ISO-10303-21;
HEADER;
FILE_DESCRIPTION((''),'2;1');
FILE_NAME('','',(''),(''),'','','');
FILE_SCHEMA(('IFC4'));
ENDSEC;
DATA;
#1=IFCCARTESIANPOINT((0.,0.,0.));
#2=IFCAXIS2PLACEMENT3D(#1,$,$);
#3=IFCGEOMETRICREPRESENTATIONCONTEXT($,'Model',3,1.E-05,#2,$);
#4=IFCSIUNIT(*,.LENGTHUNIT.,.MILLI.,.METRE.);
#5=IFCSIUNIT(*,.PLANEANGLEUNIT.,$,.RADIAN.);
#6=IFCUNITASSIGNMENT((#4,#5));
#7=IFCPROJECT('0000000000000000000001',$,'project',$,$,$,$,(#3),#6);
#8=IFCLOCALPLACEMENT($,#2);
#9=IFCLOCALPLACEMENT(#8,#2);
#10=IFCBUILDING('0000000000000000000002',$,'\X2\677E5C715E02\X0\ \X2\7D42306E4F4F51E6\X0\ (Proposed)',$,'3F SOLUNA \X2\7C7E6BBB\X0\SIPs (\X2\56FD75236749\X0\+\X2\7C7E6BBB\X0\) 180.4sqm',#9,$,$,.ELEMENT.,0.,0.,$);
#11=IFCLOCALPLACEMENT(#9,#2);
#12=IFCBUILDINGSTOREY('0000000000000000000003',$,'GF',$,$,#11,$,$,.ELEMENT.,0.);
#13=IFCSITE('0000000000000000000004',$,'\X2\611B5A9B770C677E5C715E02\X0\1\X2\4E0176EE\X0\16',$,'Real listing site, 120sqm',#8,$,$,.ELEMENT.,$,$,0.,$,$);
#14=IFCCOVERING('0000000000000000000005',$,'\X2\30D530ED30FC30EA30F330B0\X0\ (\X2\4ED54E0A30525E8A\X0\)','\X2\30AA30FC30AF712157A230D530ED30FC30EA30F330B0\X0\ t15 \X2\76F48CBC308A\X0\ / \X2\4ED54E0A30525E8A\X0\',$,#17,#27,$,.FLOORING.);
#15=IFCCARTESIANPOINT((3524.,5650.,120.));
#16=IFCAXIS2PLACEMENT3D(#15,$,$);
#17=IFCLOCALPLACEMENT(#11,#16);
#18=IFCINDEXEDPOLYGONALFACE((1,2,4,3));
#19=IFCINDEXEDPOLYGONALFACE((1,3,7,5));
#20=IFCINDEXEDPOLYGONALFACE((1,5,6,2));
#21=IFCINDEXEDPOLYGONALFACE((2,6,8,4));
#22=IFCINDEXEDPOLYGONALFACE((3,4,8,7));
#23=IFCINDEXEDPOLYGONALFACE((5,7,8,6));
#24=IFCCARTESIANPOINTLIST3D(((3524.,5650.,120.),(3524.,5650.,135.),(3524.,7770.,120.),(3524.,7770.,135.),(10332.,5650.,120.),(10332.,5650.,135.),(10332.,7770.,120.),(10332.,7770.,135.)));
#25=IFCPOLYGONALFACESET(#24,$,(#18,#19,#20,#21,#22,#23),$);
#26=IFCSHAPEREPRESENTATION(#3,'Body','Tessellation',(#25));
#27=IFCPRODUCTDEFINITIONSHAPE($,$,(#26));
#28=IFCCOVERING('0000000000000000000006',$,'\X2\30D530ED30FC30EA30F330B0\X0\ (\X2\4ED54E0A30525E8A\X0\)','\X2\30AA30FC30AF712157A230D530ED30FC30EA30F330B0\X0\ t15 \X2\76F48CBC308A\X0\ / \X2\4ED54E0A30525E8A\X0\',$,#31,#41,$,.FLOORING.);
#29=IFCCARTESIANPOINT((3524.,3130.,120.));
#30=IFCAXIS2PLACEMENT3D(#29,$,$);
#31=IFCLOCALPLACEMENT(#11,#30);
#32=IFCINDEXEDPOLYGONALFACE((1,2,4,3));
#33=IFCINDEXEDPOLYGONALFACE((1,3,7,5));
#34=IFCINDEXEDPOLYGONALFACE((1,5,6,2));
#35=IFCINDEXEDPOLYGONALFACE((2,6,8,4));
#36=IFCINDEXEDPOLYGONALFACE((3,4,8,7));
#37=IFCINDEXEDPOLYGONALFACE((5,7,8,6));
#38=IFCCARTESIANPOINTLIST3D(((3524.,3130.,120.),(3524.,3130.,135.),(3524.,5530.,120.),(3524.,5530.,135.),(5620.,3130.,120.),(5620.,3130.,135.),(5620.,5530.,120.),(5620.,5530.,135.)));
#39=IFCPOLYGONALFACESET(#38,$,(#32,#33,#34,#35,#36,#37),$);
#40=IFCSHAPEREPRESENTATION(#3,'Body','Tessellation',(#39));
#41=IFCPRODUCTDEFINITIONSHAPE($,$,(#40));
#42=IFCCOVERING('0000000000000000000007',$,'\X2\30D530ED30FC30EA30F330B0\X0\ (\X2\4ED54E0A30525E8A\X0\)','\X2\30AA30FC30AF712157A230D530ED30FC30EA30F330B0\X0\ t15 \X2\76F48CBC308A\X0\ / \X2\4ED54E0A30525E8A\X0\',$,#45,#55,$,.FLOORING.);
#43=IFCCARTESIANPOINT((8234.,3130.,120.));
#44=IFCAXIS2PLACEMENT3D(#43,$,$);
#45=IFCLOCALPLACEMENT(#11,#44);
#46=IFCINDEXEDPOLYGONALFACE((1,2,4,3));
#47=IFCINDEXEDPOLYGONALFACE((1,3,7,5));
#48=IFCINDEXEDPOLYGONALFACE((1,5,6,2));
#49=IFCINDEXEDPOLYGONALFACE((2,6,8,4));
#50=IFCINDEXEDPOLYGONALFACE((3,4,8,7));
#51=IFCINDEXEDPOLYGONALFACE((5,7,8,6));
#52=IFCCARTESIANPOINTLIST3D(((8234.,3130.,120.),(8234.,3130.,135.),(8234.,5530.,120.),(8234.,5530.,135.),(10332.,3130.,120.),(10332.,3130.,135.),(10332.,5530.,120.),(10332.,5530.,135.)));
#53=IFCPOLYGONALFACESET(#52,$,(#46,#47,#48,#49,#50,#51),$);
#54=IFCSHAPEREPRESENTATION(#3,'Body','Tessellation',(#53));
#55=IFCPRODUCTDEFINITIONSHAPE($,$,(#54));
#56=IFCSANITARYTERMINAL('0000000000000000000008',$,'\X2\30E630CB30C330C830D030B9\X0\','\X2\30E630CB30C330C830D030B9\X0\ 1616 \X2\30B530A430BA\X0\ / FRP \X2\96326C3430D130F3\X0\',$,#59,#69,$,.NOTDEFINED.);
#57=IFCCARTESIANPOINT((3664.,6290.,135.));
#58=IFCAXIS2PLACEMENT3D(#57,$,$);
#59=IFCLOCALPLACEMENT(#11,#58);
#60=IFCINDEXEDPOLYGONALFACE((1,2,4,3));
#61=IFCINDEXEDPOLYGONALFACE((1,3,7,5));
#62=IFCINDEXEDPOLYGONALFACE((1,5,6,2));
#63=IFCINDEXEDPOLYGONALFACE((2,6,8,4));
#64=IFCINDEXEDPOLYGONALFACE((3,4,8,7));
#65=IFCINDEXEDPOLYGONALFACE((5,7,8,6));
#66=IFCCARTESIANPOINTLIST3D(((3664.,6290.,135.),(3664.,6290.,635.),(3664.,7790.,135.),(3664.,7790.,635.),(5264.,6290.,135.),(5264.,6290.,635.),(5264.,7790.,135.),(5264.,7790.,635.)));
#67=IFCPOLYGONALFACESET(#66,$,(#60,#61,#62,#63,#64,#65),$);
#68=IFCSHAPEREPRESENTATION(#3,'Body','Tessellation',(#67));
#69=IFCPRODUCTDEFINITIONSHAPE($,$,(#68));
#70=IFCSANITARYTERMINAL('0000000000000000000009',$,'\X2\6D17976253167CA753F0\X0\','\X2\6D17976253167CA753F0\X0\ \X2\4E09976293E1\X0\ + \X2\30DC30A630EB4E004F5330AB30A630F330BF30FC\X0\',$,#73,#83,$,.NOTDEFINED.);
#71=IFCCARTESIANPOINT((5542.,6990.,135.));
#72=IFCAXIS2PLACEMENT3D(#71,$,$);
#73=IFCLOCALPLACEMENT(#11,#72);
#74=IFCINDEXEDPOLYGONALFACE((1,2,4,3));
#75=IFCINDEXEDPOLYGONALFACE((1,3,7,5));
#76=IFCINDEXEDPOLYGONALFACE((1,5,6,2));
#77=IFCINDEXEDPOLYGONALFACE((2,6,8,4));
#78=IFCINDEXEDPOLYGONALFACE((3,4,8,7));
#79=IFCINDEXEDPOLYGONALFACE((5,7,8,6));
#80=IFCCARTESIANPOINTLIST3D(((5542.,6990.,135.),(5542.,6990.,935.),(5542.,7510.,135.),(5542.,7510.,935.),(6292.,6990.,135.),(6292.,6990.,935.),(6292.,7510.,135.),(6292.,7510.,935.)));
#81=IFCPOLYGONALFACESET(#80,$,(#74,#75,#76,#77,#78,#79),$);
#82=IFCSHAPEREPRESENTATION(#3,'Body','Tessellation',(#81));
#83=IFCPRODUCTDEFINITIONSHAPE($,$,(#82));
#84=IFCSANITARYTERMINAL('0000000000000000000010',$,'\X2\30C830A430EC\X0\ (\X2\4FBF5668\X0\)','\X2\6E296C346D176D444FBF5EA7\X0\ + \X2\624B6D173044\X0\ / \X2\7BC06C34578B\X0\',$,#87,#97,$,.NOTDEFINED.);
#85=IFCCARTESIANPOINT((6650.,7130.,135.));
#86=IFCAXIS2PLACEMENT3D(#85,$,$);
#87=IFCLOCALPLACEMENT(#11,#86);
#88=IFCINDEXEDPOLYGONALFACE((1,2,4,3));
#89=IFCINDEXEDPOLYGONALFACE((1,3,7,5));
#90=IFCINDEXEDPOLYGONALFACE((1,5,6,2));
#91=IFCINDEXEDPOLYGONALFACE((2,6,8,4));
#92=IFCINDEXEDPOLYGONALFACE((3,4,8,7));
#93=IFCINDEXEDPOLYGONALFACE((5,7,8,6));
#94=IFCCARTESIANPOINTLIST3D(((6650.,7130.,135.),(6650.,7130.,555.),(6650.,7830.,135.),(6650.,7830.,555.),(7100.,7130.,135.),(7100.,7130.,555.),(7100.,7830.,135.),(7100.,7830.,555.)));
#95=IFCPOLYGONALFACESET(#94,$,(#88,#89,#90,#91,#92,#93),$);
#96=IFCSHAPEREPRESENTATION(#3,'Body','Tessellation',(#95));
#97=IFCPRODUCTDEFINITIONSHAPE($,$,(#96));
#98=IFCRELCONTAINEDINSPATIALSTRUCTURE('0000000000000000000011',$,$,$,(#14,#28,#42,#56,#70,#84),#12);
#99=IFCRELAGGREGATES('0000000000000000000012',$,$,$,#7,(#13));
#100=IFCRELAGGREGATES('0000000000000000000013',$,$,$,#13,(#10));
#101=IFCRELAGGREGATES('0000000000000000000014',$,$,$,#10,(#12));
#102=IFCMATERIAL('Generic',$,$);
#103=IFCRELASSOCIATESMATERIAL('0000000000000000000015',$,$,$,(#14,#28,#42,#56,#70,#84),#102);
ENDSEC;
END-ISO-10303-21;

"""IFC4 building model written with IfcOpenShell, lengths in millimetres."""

from ifc_helpers import new_model, si_unit, frame, frame_2d, origin, place, context, project, spatial, rectangle, extrude, material, element, save


model = new_model("IFC4")

# Units and contexts
model_context = context("Model", 3, precision=1e-05, world=origin())
ifc_project = project(units=[si_unit("LENGTHUNIT", "METRE", prefix="MILLI"), si_unit("PLANEANGLEUNIT", "RADIAN")], contexts=[model_context])

# Site, building, storey
site_placement = place(None, origin())
site = spatial("IfcSite", under=ifc_project, at=site_placement, Name="愛媛県松山市1丁目16", ObjectType="Real listing site, 120sqm", CompositionType="ELEMENT", RefElevation=0.0)
building_placement = place(site_placement, origin())
building = spatial("IfcBuilding", under=site, at=building_placement, Name="松山市 終の住処 (Proposed)", ObjectType="3F SOLUNA 籾殻SIPs (国産杉+籾殻) 180.4sqm", CompositionType="ELEMENT", ElevationOfRefHeight=0.0, ElevationOfTerrain=0.0)
storey_placement = place(building_placement, origin())
storey = spatial("IfcBuildingStorey", under=building, at=storey_placement, Name="GF", CompositionType="ELEMENT", Elevation=0.0)

# Coverings
ifc_material_1 = material(Name="Generic")
covering_1_placement = place(storey_placement, frame((3524.0, 5650.0, 120.0)))
element("IfcCovering", 1, at=covering_1_placement, inside=storey, material=ifc_material_1, Name="フローリング (仕上げ床)", Description="オーク無垢フローリング t15 直貼り / 仕上げ床", PredefinedType="FLOORING", context=model_context, shape_type="SweptSolid", body=[
    extrude(rectangle(XDim=6808.0, YDim=2120.0, at=frame_2d((3404.0, 1060.0))), frame((3524.0, 5650.0, 120.0)), (0.0, 0.0, 1.0), 15.0),
])
covering_2_placement = place(storey_placement, frame((3524.0, 3130.0, 120.0)))
element("IfcCovering", 2, at=covering_2_placement, inside=storey, material=ifc_material_1, Name="フローリング (仕上げ床)", Description="オーク無垢フローリング t15 直貼り / 仕上げ床", PredefinedType="FLOORING", context=model_context, shape_type="SweptSolid", body=[
    extrude(rectangle(XDim=2096.0, YDim=2400.0, at=frame_2d((1048.0, 1200.0))), frame((3524.0, 3130.0, 120.0)), (0.0, 0.0, 1.0), 15.0),
])
covering_3_placement = place(storey_placement, frame((8234.0, 3130.0, 120.0)))
element("IfcCovering", 3, at=covering_3_placement, inside=storey, material=ifc_material_1, Name="フローリング (仕上げ床)", Description="オーク無垢フローリング t15 直貼り / 仕上げ床", PredefinedType="FLOORING", context=model_context, shape_type="SweptSolid", body=[
    extrude(rectangle(XDim=2098.0, YDim=2400.0, at=frame_2d((1049.0, 1200.0))), frame((8234.0, 3130.0, 120.0)), (0.0, 0.0, 1.0), 15.0),
])

# Sanitary terminals
sanitary_terminal_1_placement = place(storey_placement, frame((3664.0, 6290.0, 135.0)))
element("IfcSanitaryTerminal", 4, at=sanitary_terminal_1_placement, inside=storey, material=ifc_material_1, Name="ユニットバス", Description="ユニットバス 1616 サイズ / FRP 防水パン", PredefinedType="NOTDEFINED", context=model_context, shape_type="SweptSolid", body=[
    extrude(rectangle(XDim=1600.0, YDim=1500.0, at=frame_2d((800.0, 750.0))), frame((3664.0, 6290.0, 135.0)), (0.0, 0.0, 1.0), 500.0),
])
sanitary_terminal_2_placement = place(storey_placement, frame((5542.0, 6990.0, 135.0)))
element("IfcSanitaryTerminal", 5, at=sanitary_terminal_2_placement, inside=storey, material=ifc_material_1, Name="洗面化粧台", Description="洗面化粧台 三面鏡 + ボウル一体カウンター", PredefinedType="NOTDEFINED", context=model_context, shape_type="SweptSolid", body=[
    extrude(rectangle(XDim=750.0, YDim=520.0, at=frame_2d((375.0, 260.0))), frame((5542.0, 6990.0, 135.0)), (0.0, 0.0, 1.0), 800.0),
])
sanitary_terminal_3_placement = place(storey_placement, frame((6650.0, 7130.0, 135.0)))
element("IfcSanitaryTerminal", 6, at=sanitary_terminal_3_placement, inside=storey, material=ifc_material_1, Name="トイレ (便器)", Description="温水洗浄便座 + 手洗い / 節水型", PredefinedType="NOTDEFINED", context=model_context, shape_type="SweptSolid", body=[
    extrude(rectangle(XDim=450.0, YDim=700.0, at=frame_2d((225.0, 350.0))), frame((6650.0, 7130.0, 135.0)), (0.0, 0.0, 1.0), 420.0),
])

save(model, "model.ifc")
